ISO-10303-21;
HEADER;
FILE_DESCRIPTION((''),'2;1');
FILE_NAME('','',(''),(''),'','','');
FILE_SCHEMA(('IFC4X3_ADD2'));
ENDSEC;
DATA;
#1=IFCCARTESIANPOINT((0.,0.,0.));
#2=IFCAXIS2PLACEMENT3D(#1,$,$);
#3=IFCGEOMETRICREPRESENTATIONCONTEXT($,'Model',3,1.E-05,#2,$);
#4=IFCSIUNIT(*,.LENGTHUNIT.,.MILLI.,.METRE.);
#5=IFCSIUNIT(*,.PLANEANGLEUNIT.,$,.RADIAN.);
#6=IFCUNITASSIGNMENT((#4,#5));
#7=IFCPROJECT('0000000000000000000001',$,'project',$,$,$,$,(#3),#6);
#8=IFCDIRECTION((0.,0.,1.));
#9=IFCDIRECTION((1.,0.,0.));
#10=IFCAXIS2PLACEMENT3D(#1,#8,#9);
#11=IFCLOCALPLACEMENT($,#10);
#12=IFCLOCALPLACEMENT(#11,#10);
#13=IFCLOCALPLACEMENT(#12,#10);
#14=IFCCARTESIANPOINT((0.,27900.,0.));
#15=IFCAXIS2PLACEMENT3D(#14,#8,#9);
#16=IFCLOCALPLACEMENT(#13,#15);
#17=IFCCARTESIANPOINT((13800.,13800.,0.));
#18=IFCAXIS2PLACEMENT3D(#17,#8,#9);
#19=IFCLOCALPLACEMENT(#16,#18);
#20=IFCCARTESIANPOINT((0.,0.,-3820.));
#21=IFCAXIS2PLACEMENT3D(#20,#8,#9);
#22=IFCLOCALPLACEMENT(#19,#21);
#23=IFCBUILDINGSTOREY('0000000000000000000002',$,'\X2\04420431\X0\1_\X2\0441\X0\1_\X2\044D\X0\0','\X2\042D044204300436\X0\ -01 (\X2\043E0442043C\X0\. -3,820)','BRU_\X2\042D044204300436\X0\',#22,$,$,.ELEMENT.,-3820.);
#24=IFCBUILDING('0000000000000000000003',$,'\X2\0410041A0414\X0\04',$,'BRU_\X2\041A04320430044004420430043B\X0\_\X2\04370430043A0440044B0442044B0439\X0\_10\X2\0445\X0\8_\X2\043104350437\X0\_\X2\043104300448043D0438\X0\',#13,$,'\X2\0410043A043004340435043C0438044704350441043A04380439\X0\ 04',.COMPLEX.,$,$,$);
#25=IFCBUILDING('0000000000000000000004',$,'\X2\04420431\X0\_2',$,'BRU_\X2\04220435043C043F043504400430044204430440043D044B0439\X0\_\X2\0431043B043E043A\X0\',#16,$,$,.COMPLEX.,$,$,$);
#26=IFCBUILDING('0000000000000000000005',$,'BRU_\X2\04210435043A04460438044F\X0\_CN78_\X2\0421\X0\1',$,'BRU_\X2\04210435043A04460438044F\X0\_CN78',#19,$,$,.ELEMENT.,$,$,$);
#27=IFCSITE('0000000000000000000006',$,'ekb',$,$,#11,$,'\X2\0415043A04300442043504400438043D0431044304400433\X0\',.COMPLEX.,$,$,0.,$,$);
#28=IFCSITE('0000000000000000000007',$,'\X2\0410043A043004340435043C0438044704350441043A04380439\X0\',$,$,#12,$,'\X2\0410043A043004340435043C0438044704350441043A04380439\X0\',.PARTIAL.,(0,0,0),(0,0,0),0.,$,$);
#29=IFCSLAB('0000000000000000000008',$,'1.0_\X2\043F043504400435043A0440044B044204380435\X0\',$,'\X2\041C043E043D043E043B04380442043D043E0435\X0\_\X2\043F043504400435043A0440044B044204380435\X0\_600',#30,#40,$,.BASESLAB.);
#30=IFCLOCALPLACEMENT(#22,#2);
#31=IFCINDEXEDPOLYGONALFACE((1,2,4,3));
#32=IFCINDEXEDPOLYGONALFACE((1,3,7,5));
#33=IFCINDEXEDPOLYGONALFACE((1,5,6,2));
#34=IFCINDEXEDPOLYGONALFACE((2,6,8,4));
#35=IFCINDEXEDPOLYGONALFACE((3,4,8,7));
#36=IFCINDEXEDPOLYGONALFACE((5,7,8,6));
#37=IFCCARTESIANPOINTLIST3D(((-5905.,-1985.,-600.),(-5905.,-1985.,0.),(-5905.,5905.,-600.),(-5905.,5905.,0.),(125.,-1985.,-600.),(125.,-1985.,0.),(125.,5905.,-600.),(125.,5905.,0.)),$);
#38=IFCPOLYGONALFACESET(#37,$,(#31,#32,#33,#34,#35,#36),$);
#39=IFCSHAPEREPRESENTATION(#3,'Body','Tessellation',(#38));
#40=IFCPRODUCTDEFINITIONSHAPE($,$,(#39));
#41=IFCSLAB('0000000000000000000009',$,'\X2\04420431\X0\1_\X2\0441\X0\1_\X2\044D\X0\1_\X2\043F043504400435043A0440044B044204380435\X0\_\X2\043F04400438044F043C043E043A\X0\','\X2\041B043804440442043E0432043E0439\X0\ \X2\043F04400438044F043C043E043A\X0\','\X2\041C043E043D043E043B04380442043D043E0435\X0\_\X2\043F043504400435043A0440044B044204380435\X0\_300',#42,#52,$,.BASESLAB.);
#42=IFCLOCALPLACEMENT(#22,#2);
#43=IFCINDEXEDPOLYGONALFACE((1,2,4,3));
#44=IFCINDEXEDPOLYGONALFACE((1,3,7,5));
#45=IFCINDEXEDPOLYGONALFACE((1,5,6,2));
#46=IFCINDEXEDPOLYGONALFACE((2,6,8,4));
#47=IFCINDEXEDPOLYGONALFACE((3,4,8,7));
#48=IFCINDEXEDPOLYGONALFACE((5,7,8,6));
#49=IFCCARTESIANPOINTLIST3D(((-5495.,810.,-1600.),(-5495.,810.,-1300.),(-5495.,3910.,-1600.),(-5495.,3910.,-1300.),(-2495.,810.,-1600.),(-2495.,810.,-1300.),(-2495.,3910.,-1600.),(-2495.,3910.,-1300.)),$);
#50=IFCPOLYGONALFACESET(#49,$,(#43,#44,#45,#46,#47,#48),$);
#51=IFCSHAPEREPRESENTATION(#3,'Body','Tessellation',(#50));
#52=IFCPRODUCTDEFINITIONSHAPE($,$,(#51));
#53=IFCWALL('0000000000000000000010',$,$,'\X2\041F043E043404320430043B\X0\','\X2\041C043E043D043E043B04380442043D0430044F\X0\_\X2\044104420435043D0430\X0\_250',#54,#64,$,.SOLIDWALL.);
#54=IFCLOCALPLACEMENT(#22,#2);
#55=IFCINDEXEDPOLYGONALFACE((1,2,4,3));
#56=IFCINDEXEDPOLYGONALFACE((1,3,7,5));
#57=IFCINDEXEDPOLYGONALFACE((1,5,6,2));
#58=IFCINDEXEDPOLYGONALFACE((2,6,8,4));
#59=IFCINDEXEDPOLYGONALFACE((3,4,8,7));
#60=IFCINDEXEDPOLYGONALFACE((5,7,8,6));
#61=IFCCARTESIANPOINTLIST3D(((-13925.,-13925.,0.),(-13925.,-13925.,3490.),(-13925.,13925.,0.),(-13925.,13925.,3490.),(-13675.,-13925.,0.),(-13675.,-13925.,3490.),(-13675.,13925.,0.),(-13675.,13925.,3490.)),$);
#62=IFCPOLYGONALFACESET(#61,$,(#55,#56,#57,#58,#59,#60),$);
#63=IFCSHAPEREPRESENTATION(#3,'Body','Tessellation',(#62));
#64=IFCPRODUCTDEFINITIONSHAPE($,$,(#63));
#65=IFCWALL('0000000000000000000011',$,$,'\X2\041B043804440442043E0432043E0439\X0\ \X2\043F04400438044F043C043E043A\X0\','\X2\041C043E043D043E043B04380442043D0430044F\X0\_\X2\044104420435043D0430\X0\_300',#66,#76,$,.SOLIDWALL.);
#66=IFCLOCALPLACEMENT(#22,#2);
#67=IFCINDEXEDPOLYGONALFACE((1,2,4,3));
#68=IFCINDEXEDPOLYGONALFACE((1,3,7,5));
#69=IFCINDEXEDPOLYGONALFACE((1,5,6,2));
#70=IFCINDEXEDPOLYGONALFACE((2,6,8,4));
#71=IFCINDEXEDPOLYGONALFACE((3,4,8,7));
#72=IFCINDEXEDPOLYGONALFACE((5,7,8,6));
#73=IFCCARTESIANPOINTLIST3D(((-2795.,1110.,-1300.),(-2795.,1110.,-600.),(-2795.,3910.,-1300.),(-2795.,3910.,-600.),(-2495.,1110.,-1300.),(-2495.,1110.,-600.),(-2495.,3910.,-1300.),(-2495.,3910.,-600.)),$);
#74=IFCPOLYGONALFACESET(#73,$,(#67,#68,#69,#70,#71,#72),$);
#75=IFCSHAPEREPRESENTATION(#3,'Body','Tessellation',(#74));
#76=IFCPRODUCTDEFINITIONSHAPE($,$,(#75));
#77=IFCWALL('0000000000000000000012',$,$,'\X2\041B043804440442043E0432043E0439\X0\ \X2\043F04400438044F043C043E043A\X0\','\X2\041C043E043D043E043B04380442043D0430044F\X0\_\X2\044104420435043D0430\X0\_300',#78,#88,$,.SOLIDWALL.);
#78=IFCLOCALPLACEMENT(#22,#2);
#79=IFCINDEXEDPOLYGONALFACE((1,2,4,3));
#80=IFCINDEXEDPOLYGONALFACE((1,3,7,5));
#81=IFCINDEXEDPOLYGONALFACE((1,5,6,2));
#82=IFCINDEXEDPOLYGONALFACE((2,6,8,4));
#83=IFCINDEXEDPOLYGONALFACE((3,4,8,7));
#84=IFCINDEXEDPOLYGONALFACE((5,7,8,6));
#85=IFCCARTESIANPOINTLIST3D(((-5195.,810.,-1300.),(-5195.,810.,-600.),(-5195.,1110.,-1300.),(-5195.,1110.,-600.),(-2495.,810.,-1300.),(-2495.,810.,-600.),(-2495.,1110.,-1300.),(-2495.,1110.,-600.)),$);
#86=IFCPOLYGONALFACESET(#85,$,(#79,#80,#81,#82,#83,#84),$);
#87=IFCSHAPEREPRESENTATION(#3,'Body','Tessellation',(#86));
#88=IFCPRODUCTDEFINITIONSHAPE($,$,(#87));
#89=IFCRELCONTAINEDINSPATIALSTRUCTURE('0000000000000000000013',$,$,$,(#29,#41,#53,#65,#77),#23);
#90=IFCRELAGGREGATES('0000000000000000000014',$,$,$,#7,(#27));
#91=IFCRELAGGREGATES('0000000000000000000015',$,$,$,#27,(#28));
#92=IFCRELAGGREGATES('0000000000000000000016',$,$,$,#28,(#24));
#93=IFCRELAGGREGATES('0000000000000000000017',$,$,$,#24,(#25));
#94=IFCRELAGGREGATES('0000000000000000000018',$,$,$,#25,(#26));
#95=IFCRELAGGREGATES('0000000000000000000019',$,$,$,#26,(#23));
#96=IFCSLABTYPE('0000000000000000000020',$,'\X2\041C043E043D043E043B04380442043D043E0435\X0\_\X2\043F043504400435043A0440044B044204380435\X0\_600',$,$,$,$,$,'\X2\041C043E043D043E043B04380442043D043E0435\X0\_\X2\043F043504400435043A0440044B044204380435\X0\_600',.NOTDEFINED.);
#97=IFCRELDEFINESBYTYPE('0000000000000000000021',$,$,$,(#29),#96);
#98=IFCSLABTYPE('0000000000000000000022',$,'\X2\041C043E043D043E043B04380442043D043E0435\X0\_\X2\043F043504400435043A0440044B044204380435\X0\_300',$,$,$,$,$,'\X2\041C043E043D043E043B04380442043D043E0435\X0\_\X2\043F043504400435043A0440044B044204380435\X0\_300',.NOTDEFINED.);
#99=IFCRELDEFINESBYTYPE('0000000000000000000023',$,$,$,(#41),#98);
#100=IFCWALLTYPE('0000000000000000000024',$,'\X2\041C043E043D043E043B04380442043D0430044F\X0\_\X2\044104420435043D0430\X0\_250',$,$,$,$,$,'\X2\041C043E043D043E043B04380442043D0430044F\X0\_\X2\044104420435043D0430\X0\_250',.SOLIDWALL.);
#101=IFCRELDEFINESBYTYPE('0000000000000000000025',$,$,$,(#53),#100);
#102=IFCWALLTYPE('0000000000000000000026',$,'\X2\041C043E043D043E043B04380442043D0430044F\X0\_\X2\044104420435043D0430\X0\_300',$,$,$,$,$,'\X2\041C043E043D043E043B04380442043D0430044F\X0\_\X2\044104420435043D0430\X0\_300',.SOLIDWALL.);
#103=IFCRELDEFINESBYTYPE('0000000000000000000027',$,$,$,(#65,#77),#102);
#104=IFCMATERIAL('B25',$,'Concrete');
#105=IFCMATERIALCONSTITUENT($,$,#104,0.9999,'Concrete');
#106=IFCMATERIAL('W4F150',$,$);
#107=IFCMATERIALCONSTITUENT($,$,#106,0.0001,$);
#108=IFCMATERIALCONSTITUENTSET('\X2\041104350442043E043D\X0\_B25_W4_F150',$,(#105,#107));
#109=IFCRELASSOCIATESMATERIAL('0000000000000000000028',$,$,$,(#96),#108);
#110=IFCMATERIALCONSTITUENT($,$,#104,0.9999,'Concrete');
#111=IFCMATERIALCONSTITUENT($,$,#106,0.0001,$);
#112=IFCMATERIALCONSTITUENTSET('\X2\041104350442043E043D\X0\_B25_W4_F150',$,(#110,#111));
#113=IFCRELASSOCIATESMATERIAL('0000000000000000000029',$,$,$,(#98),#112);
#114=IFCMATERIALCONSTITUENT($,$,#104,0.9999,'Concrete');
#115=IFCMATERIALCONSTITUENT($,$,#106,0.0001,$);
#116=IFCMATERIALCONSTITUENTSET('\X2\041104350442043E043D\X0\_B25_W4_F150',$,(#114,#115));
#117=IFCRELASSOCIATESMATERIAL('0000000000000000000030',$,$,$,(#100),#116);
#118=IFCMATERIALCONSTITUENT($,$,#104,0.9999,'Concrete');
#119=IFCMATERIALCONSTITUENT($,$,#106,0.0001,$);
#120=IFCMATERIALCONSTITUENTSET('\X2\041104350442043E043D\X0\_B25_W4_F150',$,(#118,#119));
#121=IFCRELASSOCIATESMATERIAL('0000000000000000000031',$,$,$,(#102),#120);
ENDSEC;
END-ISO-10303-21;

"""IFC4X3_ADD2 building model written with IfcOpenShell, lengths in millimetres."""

from ifc_helpers import new_model, si_unit, frame, origin, origin_with_axes, origin_2d_with_axis, place, context, project, spatial, polyline, rectangle, outline, extrude, material, constituent, constituent_set, type_object, element, save


model = new_model("IFC4X3_ADD2")

# Units and contexts
model_context = context("Model", 3, precision=1e-05, world=origin())
ifc_project = project(units=[si_unit("LENGTHUNIT", "METRE", prefix="MILLI"), si_unit("PLANEANGLEUNIT", "RADIAN")], contexts=[model_context])

# Sites, buildings, storey
site_1_placement = place(None, origin_with_axes())
site_1 = spatial("IfcSite", under=ifc_project, at=site_1_placement, Name="ekb", LongName="Екатеринбург", CompositionType="COMPLEX", RefElevation=0.0)
site_2_placement = place(site_1_placement, origin_with_axes())
site_2 = spatial("IfcSite", under=site_1, at=site_2_placement, Name="Академический", LongName="Академический", CompositionType="PARTIAL", RefLatitude=(0, 0, 0), RefLongitude=(0, 0, 0), RefElevation=0.0)
building_1_placement = place(site_2_placement, origin_with_axes())
building_1 = spatial("IfcBuilding", under=site_2, at=building_1_placement, Name="АКД04", ObjectType="BRU_Квартал_закрытый_10х8_без_башни", LongName="Академический 04", CompositionType="COMPLEX")
building_2_placement = place(building_1_placement, frame((0.0, 27900.0, 0.0), z_axis=(0.0, 0.0, 1.0), x_axis=(1.0, 0.0, 0.0)))
building_2 = spatial("IfcBuilding", under=building_1, at=building_2_placement, Name="тб_2", ObjectType="BRU_Температурный_блок", CompositionType="COMPLEX")
building_3_placement = place(building_2_placement, frame((13800.0, 13800.0, 0.0), z_axis=(0.0, 0.0, 1.0), x_axis=(1.0, 0.0, 0.0)))
building_3 = spatial("IfcBuilding", under=building_2, at=building_3_placement, Name="BRU_Секция_CN78_С1", ObjectType="BRU_Секция_CN78", CompositionType="ELEMENT")
storey_placement = place(building_3_placement, frame((0.0, 0.0, -3820.0), z_axis=(0.0, 0.0, 1.0), x_axis=(1.0, 0.0, 0.0)))
storey = spatial("IfcBuildingStorey", under=building_3, at=storey_placement, Name="тб1_с1_э0", Description="Этаж -01 (отм. -3,820)", ObjectType="BRU_Этаж", CompositionType="ELEMENT", Elevation=-3820.0)

# Shared definitions
ifc_material_1 = material(Name="B25", Category="Concrete")
ifc_material_2 = material(Name="W4F150")

# Slabs
ifc_constituent_1 = constituent(ifc_material_1, Category="Concrete", fraction=0.9999)
ifc_constituent_2 = constituent(ifc_material_2, fraction=0.0001)
ifc_constituent_set_1 = constituent_set(constituents=[ifc_constituent_1, ifc_constituent_2], Name="Бетон_B25_W4_F150")
slab_type_1 = type_object("IfcSlabType", Name="Монолитное_перекрытие_600", ElementType="Монолитное_перекрытие_600", PredefinedType="NOTDEFINED", material=ifc_constituent_set_1)
slab_1_placement = place(storey_placement, frame((0.0, 0.0, -600.0), z_axis=(0.0, 0.0, 1.0), x_axis=(1.0, 0.0, 0.0)))
element("IfcSlab", 1, at=slab_1_placement, inside=storey, type_object=slab_type_1, Name="1.0_перекрытие", ObjectType="Монолитное_перекрытие_600", PredefinedType="BASESLAB", context=model_context, shape_type="SweptSolid", body=[
    extrude(outline(polyline([(-5905.0, -1985.0), (125.0, -1985.0), (125.0, 5905.0), (-5905.0, 5905.0), (-5905.0, -1985.0)])), origin_with_axes(), (0.0, 0.0, 1.0), 600.0),
])
ifc_constituent_3 = constituent(ifc_material_1, Category="Concrete", fraction=0.9999)
ifc_constituent_4 = constituent(ifc_material_2, fraction=0.0001)
ifc_constituent_set_2 = constituent_set(constituents=[ifc_constituent_3, ifc_constituent_4], Name="Бетон_B25_W4_F150")
slab_type_2 = type_object("IfcSlabType", Name="Монолитное_перекрытие_300", ElementType="Монолитное_перекрытие_300", PredefinedType="NOTDEFINED", material=ifc_constituent_set_2)
slab_2_placement = place(storey_placement, frame((-3995.0, 2360.0, -1600.0), z_axis=(0.0, 0.0, 1.0), x_axis=(0.0, 1.0, 0.0)))
element("IfcSlab", 2, at=slab_2_placement, inside=storey, type_object=slab_type_2, Name="тб1_с1_э1_перекрытие_приямок", Description="Лифтовой приямок", ObjectType="Монолитное_перекрытие_300", PredefinedType="BASESLAB", context=model_context, shape_type="SweptSolid", body=[
    extrude(outline(polyline([(-1550.0, -1500.0), (-1550.0, 1500.0), (1550.0, 1500.0), (1550.0, -1500.0), (-1550.0, -1500.0)])), origin_with_axes(), (0.0, 0.0, 1.0), 300.0),
])

# Walls
ifc_constituent_5 = constituent(ifc_material_1, Category="Concrete", fraction=0.9999)
ifc_constituent_6 = constituent(ifc_material_2, fraction=0.0001)
ifc_constituent_set_3 = constituent_set(constituents=[ifc_constituent_5, ifc_constituent_6], Name="Бетон_B25_W4_F150")
wall_type_1 = type_object("IfcWallType", Name="Монолитная_стена_250", ElementType="Монолитная_стена_250", PredefinedType="SOLIDWALL", material=ifc_constituent_set_3)
wall_1_placement = place(storey_placement, frame((-13800.0, -13925.0, 0.0), z_axis=(0.0, 0.0, 1.0), x_axis=(0.0, 1.0, 0.0)))
element("IfcWall", 3, at=wall_1_placement, inside=storey, type_object=wall_type_1, Description="Подвал", ObjectType="Монолитная_стена_250", PredefinedType="SOLIDWALL", context=model_context, shape_type="SweptSolid", body=[
    extrude(rectangle(XDim=27850.0, YDim=250.0, at=origin_2d_with_axis()), frame((13925.0, 0.0, 0.0), z_axis=(0.0, 0.0, 1.0), x_axis=(1.0, 0.0, 0.0)), (0.0, 0.0, 1.0), 3490.0),
])
ifc_constituent_7 = constituent(ifc_material_1, Category="Concrete", fraction=0.9999)
ifc_constituent_8 = constituent(ifc_material_2, fraction=0.0001)
ifc_constituent_set_4 = constituent_set(constituents=[ifc_constituent_7, ifc_constituent_8], Name="Бетон_B25_W4_F150")
wall_type_2 = type_object("IfcWallType", Name="Монолитная_стена_300", ElementType="Монолитная_стена_300", PredefinedType="SOLIDWALL", material=ifc_constituent_set_4)
wall_2_placement = place(storey_placement, frame((-2645.0, 1110.0, -1300.0), z_axis=(0.0, 0.0, 1.0), x_axis=(0.0, 1.0, 0.0)))
element("IfcWall", 4, at=wall_2_placement, inside=storey, type_object=wall_type_2, Description="Лифтовой приямок", ObjectType="Монолитная_стена_300", PredefinedType="SOLIDWALL", context=model_context, shape_type="SweptSolid", body=[
    extrude(rectangle(XDim=2800.0, YDim=300.0, at=origin_2d_with_axis()), frame((1400.0, 0.0, 0.0), z_axis=(0.0, 0.0, 1.0), x_axis=(1.0, 0.0, 0.0)), (0.0, 0.0, 1.0), 700.0),
])
wall_3_placement = place(storey_placement, frame((-5195.0, 960.0, -1300.0), z_axis=(0.0, 0.0, 1.0), x_axis=(1.0, 0.0, 0.0)))
element("IfcWall", 5, at=wall_3_placement, inside=storey, type_object=wall_type_2, Description="Лифтовой приямок", ObjectType="Монолитная_стена_300", PredefinedType="SOLIDWALL", context=model_context, shape_type="SweptSolid", body=[
    extrude(rectangle(XDim=2700.0, YDim=300.0, at=origin_2d_with_axis()), frame((1350.0, 0.0, 0.0), z_axis=(0.0, 0.0, 1.0), x_axis=(1.0, 0.0, 0.0)), (0.0, 0.0, 1.0), 700.0),
])

save(model, "model.ifc")
